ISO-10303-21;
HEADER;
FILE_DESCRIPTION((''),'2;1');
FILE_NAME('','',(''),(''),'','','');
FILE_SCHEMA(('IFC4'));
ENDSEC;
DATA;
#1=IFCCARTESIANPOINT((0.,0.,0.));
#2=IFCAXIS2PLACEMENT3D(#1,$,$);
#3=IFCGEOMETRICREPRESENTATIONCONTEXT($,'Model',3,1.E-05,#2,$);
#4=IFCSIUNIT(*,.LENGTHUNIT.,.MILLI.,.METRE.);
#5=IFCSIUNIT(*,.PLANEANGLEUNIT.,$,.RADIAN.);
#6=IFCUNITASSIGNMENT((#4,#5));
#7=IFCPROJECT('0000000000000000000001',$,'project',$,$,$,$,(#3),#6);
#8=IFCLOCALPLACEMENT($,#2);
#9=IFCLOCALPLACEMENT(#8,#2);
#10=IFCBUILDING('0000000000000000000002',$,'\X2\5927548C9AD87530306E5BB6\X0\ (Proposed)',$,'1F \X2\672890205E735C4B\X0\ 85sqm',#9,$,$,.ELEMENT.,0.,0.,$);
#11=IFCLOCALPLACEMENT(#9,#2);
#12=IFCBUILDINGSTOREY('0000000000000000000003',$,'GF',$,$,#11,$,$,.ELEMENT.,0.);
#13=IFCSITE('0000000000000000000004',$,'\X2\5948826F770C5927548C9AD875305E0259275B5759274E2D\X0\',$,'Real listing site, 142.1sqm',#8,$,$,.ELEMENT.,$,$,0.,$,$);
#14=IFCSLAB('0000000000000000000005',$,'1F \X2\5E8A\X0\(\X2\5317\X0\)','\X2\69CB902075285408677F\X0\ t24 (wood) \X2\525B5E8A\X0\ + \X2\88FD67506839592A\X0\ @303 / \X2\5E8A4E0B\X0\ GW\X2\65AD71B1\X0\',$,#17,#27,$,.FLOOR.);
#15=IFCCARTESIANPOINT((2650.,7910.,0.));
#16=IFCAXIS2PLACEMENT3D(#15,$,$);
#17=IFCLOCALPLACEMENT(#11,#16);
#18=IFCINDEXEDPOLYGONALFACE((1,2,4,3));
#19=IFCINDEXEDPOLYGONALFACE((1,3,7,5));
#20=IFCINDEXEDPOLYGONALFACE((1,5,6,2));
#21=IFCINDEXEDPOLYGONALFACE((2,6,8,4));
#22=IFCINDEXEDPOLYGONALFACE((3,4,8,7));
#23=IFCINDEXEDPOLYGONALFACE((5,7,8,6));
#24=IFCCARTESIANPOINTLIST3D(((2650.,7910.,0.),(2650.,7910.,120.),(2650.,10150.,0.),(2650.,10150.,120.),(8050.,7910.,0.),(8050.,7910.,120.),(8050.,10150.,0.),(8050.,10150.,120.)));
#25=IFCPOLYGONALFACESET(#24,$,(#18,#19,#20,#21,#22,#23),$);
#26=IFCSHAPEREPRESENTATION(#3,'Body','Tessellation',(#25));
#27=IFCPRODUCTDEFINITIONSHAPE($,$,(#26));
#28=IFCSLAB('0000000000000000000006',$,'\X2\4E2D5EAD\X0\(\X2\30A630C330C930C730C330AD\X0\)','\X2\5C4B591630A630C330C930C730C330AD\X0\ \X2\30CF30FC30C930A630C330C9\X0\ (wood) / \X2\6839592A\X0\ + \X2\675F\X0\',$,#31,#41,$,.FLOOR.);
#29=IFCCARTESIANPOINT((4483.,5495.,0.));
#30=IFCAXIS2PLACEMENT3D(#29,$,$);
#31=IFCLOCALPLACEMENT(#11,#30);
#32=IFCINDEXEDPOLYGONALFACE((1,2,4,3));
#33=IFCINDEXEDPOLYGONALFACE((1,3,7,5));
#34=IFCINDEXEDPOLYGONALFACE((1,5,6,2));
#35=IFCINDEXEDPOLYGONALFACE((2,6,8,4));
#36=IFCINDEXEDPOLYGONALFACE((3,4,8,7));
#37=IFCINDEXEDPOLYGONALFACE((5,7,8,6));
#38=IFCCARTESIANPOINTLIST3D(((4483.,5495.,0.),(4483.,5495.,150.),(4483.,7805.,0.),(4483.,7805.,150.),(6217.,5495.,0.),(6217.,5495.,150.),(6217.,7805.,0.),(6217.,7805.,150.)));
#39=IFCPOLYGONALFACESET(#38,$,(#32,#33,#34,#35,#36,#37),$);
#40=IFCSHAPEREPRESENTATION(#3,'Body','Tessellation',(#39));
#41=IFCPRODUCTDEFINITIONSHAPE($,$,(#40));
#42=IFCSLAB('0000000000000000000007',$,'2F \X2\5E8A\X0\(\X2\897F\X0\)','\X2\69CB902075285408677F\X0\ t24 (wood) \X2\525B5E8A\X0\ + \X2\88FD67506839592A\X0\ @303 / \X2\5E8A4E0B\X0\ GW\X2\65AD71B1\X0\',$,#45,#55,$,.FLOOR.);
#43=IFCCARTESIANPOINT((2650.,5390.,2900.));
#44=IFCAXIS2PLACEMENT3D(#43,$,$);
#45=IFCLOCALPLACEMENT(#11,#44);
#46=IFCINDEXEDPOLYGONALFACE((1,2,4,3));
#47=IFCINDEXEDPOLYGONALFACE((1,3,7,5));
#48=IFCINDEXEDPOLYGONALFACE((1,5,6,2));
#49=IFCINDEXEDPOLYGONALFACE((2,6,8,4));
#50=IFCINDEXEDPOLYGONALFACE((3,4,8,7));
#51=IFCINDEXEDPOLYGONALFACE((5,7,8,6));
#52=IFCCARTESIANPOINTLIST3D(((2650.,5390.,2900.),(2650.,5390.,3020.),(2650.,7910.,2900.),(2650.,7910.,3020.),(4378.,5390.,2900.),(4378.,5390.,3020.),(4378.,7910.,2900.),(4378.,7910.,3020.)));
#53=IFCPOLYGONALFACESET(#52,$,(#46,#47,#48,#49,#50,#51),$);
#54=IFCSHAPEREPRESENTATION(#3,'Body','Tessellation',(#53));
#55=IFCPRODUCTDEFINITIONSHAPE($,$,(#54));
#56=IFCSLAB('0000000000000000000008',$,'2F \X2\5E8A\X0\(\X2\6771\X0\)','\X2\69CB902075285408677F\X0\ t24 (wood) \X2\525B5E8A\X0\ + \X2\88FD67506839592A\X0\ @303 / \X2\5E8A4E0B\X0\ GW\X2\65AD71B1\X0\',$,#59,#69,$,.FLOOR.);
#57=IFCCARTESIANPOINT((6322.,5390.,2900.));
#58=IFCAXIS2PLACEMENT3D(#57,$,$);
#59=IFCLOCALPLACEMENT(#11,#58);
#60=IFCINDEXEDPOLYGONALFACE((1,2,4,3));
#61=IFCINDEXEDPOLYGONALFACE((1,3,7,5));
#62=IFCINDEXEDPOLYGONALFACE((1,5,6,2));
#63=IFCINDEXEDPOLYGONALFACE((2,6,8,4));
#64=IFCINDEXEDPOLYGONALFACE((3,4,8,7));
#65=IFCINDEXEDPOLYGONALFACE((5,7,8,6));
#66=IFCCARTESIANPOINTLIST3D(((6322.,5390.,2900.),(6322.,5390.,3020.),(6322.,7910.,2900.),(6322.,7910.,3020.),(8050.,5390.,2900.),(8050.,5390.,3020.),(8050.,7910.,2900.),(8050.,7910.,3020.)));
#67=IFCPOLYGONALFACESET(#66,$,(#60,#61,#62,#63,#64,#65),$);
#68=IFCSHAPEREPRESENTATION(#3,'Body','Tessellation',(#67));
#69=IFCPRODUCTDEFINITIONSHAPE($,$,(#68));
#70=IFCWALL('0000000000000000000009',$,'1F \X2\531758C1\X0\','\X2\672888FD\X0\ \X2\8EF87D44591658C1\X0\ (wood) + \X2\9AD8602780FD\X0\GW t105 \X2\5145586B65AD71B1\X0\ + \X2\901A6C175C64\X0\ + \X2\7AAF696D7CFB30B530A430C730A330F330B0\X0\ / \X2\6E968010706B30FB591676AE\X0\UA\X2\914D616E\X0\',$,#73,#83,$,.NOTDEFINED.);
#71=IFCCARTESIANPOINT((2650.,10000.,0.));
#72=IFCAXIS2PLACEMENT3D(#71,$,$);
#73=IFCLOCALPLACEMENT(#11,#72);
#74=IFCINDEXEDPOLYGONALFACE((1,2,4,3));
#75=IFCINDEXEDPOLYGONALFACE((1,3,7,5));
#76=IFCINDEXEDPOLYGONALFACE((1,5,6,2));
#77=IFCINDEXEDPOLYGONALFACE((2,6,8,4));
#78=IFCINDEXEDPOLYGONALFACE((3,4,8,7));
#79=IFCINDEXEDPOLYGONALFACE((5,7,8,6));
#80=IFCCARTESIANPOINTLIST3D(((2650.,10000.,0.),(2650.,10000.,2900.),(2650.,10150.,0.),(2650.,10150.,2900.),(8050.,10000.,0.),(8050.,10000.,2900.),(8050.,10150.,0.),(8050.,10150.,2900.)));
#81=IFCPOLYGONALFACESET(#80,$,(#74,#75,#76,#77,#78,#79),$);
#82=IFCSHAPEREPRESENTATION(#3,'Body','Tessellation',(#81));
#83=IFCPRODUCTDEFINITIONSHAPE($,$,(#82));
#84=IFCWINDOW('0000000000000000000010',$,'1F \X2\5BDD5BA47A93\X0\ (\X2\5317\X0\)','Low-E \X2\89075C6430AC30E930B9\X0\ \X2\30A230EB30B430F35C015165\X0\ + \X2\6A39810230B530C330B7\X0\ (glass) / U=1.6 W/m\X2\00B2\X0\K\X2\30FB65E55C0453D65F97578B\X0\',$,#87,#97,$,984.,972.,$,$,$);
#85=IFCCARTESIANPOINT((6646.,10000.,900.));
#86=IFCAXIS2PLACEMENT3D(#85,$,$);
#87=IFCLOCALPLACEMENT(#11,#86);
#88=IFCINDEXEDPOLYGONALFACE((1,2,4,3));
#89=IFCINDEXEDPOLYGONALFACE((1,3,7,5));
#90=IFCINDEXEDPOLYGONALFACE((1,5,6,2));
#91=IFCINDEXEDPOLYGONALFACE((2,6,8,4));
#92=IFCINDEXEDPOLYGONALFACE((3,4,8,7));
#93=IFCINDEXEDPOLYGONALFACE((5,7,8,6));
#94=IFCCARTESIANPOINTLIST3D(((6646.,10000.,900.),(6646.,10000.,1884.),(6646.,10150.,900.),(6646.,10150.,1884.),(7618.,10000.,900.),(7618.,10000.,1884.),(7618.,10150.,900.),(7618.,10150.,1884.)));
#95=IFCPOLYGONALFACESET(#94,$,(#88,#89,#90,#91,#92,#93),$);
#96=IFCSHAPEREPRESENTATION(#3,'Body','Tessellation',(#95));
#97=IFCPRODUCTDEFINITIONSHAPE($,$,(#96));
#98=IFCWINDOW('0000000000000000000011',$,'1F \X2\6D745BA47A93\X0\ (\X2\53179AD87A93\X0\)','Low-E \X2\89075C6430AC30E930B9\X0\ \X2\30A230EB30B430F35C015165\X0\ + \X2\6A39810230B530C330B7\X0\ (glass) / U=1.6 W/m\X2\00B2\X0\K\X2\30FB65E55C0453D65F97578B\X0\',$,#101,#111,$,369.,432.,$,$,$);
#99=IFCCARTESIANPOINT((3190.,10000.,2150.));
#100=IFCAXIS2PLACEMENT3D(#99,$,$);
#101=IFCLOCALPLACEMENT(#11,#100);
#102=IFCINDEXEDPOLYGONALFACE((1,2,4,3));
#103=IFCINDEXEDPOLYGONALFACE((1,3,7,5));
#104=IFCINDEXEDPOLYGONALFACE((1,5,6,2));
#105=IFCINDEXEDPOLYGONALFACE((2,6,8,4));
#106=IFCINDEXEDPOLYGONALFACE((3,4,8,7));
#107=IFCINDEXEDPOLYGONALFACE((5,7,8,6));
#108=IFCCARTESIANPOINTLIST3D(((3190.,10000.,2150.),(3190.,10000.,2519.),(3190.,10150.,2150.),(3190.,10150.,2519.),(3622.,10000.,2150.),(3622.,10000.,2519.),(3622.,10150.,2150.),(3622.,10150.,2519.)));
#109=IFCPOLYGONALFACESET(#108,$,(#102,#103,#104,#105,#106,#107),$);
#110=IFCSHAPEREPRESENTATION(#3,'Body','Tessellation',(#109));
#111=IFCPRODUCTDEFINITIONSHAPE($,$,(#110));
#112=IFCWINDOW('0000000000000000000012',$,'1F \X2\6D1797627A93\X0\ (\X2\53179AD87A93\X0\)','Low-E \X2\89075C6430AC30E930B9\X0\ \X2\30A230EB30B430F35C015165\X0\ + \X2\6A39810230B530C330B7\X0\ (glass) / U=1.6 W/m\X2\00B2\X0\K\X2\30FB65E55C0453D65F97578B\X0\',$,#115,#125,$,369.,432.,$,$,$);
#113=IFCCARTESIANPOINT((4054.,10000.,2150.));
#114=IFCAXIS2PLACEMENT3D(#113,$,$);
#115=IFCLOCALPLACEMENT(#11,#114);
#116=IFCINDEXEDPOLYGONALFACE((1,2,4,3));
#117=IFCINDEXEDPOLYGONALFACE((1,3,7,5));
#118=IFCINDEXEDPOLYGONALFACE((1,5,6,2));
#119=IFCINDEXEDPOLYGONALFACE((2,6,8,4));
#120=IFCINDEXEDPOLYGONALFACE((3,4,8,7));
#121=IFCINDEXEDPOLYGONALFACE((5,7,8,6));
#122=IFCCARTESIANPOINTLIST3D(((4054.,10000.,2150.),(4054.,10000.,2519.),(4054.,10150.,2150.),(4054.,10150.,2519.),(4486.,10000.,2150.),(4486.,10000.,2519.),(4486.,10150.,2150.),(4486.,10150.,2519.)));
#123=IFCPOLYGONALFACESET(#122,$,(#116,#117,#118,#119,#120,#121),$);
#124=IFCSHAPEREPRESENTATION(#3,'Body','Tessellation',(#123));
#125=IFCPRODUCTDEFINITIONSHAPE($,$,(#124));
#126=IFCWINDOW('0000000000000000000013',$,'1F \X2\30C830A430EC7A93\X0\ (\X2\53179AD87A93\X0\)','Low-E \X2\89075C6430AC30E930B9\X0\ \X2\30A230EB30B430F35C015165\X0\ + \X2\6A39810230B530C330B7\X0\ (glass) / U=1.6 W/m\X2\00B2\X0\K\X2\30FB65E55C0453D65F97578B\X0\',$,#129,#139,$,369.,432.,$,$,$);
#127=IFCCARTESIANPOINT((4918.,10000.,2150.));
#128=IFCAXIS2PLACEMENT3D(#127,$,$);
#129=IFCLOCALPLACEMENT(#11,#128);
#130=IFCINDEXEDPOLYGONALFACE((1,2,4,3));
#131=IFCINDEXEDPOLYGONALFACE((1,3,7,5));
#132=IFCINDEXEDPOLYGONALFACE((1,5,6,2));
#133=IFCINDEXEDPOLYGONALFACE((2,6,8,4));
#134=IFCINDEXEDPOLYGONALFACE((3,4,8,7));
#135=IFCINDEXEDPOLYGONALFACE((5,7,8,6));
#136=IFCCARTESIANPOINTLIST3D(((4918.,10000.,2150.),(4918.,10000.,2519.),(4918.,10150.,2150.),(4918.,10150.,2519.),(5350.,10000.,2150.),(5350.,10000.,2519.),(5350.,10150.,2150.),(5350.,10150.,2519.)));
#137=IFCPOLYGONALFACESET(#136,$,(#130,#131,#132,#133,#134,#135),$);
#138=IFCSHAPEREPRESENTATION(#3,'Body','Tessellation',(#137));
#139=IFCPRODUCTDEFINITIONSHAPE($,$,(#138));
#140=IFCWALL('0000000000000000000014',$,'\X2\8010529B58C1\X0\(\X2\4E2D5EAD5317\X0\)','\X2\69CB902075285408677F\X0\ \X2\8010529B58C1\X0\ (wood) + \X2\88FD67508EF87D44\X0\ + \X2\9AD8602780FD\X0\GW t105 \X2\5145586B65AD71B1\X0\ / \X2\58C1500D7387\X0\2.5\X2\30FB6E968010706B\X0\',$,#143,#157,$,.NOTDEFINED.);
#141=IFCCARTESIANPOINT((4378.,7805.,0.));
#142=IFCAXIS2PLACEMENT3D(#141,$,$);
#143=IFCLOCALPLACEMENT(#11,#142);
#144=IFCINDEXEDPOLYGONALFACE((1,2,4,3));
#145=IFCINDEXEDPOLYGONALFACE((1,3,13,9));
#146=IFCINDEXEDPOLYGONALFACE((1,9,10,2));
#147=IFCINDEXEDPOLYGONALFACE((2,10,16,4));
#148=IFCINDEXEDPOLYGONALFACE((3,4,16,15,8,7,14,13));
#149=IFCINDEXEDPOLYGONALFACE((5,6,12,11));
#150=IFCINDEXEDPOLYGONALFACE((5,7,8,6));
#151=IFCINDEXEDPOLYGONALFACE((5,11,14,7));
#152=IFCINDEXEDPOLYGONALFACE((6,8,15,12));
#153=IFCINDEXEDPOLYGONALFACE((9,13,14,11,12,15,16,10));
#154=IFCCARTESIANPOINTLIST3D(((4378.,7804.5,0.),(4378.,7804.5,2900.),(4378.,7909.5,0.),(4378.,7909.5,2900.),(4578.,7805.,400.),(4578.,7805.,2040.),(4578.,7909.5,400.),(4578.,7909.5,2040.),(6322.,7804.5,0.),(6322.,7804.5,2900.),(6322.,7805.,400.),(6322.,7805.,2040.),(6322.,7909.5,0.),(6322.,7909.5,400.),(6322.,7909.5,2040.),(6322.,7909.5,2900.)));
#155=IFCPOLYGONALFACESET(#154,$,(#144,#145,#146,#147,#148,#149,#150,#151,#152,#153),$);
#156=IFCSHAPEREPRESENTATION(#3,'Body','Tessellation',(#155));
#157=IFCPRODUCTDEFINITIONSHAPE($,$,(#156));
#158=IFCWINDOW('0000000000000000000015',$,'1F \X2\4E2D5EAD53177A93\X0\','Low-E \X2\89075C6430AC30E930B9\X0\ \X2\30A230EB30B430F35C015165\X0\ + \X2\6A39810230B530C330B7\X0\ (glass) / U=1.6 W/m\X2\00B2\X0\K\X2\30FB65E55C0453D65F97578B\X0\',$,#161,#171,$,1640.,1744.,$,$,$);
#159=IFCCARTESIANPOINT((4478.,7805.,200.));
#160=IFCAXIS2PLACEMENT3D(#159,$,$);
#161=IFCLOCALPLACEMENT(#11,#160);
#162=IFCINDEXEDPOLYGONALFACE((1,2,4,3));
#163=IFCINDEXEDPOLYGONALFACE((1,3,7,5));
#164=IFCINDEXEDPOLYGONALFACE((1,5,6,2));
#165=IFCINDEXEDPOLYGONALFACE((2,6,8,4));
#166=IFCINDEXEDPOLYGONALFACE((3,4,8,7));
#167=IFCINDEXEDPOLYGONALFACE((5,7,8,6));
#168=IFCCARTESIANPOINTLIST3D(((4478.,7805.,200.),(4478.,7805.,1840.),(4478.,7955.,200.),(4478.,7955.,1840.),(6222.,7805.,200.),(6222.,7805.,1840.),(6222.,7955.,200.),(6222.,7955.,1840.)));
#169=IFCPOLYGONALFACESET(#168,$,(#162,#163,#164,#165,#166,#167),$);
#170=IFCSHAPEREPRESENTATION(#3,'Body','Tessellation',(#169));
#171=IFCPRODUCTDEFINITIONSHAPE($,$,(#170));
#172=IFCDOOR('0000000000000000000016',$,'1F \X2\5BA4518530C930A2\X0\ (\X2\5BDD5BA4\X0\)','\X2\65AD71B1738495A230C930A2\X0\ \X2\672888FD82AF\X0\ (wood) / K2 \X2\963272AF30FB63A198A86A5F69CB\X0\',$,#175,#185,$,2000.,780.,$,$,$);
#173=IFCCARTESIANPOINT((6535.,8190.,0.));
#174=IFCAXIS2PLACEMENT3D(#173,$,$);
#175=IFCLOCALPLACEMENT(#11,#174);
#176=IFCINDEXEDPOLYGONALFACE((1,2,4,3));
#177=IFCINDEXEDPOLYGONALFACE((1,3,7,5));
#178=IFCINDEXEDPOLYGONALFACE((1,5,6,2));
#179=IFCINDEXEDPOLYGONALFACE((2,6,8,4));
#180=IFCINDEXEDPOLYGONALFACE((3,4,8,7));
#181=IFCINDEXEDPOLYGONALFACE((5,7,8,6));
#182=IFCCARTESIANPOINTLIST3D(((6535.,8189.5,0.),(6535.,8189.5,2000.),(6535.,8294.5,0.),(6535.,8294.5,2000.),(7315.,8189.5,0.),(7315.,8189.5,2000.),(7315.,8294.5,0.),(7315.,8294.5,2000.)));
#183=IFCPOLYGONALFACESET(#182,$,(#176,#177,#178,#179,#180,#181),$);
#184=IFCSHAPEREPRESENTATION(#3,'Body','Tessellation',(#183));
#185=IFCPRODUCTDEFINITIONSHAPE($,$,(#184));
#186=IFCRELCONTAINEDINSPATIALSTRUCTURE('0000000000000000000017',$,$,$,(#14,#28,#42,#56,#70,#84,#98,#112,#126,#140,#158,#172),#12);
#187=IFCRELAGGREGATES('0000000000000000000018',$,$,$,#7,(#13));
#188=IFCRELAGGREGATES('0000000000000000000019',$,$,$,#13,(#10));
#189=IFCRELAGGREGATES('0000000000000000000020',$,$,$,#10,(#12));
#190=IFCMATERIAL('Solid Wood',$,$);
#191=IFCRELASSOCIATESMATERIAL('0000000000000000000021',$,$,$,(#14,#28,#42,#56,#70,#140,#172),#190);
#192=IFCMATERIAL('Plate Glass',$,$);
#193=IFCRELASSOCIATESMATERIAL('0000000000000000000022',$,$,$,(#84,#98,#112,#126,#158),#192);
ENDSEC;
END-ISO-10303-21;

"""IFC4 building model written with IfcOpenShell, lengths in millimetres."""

from ifc_helpers import new_model, si_unit, frame, frame_2d, origin, place, context, project, spatial, rectangle, extrude, material, element, fill, save


model = new_model("IFC4")

# Units and contexts
model_context = context("Model", 3, precision=1e-05, world=origin())
ifc_project = project(units=[si_unit("LENGTHUNIT", "METRE", prefix="MILLI"), si_unit("PLANEANGLEUNIT", "RADIAN")], contexts=[model_context])

# Site, building, storey
site_placement = place(None, origin())
site = spatial("IfcSite", under=ifc_project, at=site_placement, Name="奈良県大和高田市大字大中", ObjectType="Real listing site, 142.1sqm", CompositionType="ELEMENT", RefElevation=0.0)
building_placement = place(site_placement, origin())
building = spatial("IfcBuilding", under=site, at=building_placement, Name="大和高田の家 (Proposed)", ObjectType="1F 木造平屋 85sqm", CompositionType="ELEMENT", ElevationOfRefHeight=0.0, ElevationOfTerrain=0.0)
storey_placement = place(building_placement, origin())
storey = spatial("IfcBuildingStorey", under=building, at=storey_placement, Name="GF", CompositionType="ELEMENT", Elevation=0.0)

# Slabs
ifc_material_1 = material(Name="Solid Wood")
slab_1_placement = place(storey_placement, frame((2650.0, 7910.0, 0.0)))
element("IfcSlab", 1, at=slab_1_placement, inside=storey, material=ifc_material_1, Name="1F 床(北)", Description="構造用合板 t24 (wood) 剛床 + 製材根太 @303 / 床下 GW断熱", PredefinedType="FLOOR", context=model_context, shape_type="SweptSolid", body=[
    extrude(rectangle(XDim=5400.0, YDim=2240.0, at=frame_2d((2700.0, 1120.0))), frame((2650.0, 7910.0, 0.0)), (0.0, 0.0, 1.0), 120.0),
])
slab_2_placement = place(storey_placement, frame((4483.0, 5495.0, 0.0)))
element("IfcSlab", 2, at=slab_2_placement, inside=storey, material=ifc_material_1, Name="中庭(ウッドデッキ)", Description="屋外ウッドデッキ ハードウッド (wood) / 根太 + 束", PredefinedType="FLOOR", context=model_context, shape_type="SweptSolid", body=[
    extrude(rectangle(XDim=1734.0, YDim=2310.0, at=frame_2d((867.0, 1155.0))), frame((4483.0, 5495.0, 0.0)), (0.0, 0.0, 1.0), 150.0),
])
slab_3_placement = place(storey_placement, frame((2650.0, 5390.0, 2900.0)))
element("IfcSlab", 3, at=slab_3_placement, inside=storey, material=ifc_material_1, Name="2F 床(西)", Description="構造用合板 t24 (wood) 剛床 + 製材根太 @303 / 床下 GW断熱", PredefinedType="FLOOR", context=model_context, shape_type="SweptSolid", body=[
    extrude(rectangle(XDim=1728.0, YDim=2520.0, at=frame_2d((864.0, 1260.0))), frame((2650.0, 5390.0, 2900.0)), (0.0, 0.0, 1.0), 120.0),
])
slab_4_placement = place(storey_placement, frame((6322.0, 5390.0, 2900.0)))
element("IfcSlab", 4, at=slab_4_placement, inside=storey, material=ifc_material_1, Name="2F 床(東)", Description="構造用合板 t24 (wood) 剛床 + 製材根太 @303 / 床下 GW断熱", PredefinedType="FLOOR", context=model_context, shape_type="SweptSolid", body=[
    extrude(rectangle(XDim=1728.0, YDim=2520.0, at=frame_2d((864.0, 1260.0))), frame((6322.0, 5390.0, 2900.0)), (0.0, 0.0, 1.0), 120.0),
])

# Wall, openings, windows
wall_1_placement = place(storey_placement, frame((2650.0, 10000.0, 0.0)))
wall_1 = element("IfcWall", 5, at=wall_1_placement, inside=storey, material=ifc_material_1, Name="1F 北壁", Description="木製 軸組外壁 (wood) + 高性能GW t105 充填断熱 + 通気層 + 窯業系サイディング / 準耐火・外皮UA配慮", PredefinedType="NOTDEFINED", context=model_context, shape_type="SweptSolid", body=[
    extrude(rectangle(XDim=5400.0, YDim=150.0, at=frame_2d((2700.0, 75.0))), frame((2650.0, 10000.0, 0.0)), (0.0, 0.0, 1.0), 2900.0),
])
opening_1_placement = place(storey_placement, frame((6646.0, 10000.0, 900.0)))
opening_1 = element("IfcOpeningElement", 6, at=opening_1_placement, cuts=wall_1, PredefinedType="NOTDEFINED", context=model_context, shape_type="SweptSolid", body=[
    extrude(rectangle(XDim=972.0, YDim=150.0, at=frame_2d((486.0, 75.0))), frame((6646.0, 10000.0, 900.0)), (0.0, 0.0, 1.0), 984.0),
])
opening_2_placement = place(storey_placement, frame((3190.0, 10000.0, 2150.0)))
opening_2 = element("IfcOpeningElement", 7, at=opening_2_placement, cuts=wall_1, PredefinedType="NOTDEFINED", context=model_context, shape_type="SweptSolid", body=[
    extrude(rectangle(XDim=432.0, YDim=150.0, at=frame_2d((216.0, 75.0))), frame((3190.0, 10000.0, 2150.0)), (0.0, 0.0, 1.0), 369.0),
])
opening_3_placement = place(storey_placement, frame((4054.0, 10000.0, 2150.0)))
opening_3 = element("IfcOpeningElement", 8, at=opening_3_placement, cuts=wall_1, PredefinedType="NOTDEFINED", context=model_context, shape_type="SweptSolid", body=[
    extrude(rectangle(XDim=432.0, YDim=150.0, at=frame_2d((216.0, 75.0))), frame((4054.0, 10000.0, 2150.0)), (0.0, 0.0, 1.0), 369.0),
])
opening_4_placement = place(storey_placement, frame((4918.0, 10000.0, 2150.0)))
opening_4 = element("IfcOpeningElement", 9, at=opening_4_placement, cuts=wall_1, PredefinedType="NOTDEFINED", context=model_context, shape_type="SweptSolid", body=[
    extrude(rectangle(XDim=432.0, YDim=150.0, at=frame_2d((216.0, 75.0))), frame((4918.0, 10000.0, 2150.0)), (0.0, 0.0, 1.0), 369.0),
])
ifc_material_2 = material(Name="Plate Glass")
window_1_placement = place(storey_placement, frame((6646.0, 10000.0, 900.0)))
window_1 = element("IfcWindow", 10, at=window_1_placement, inside=storey, material=ifc_material_2, Name="1F 寝室窓 (北)", Description="Low-E 複層ガラス アルゴン封入 + 樹脂サッシ (glass) / U=1.6 W/m²K・日射取得型", OverallHeight=984.0, OverallWidth=972.0, context=model_context, shape_type="SweptSolid", body=[
    extrude(rectangle(XDim=972.0, YDim=150.0, at=frame_2d((486.0, 75.0))), frame((6646.0, 10000.0, 900.0)), (0.0, 0.0, 1.0), 984.0),
])
fill(opening_1, window_1)
window_2_placement = place(storey_placement, frame((3190.0, 10000.0, 2150.0)))
window_2 = element("IfcWindow", 11, at=window_2_placement, inside=storey, material=ifc_material_2, Name="1F 浴室窓 (北高窓)", Description="Low-E 複層ガラス アルゴン封入 + 樹脂サッシ (glass) / U=1.6 W/m²K・日射取得型", OverallHeight=369.0, OverallWidth=432.0, context=model_context, shape_type="SweptSolid", body=[
    extrude(rectangle(XDim=432.0, YDim=150.0, at=frame_2d((216.0, 75.0))), frame((3190.0, 10000.0, 2150.0)), (0.0, 0.0, 1.0), 369.0),
])
fill(opening_2, window_2)
window_3_placement = place(storey_placement, frame((4054.0, 10000.0, 2150.0)))
window_3 = element("IfcWindow", 12, at=window_3_placement, inside=storey, material=ifc_material_2, Name="1F 洗面窓 (北高窓)", Description="Low-E 複層ガラス アルゴン封入 + 樹脂サッシ (glass) / U=1.6 W/m²K・日射取得型", OverallHeight=369.0, OverallWidth=432.0, context=model_context, shape_type="SweptSolid", body=[
    extrude(rectangle(XDim=432.0, YDim=150.0, at=frame_2d((216.0, 75.0))), frame((4054.0, 10000.0, 2150.0)), (0.0, 0.0, 1.0), 369.0),
])
fill(opening_3, window_3)
window_4_placement = place(storey_placement, frame((4918.0, 10000.0, 2150.0)))
window_4 = element("IfcWindow", 13, at=window_4_placement, inside=storey, material=ifc_material_2, Name="1F トイレ窓 (北高窓)", Description="Low-E 複層ガラス アルゴン封入 + 樹脂サッシ (glass) / U=1.6 W/m²K・日射取得型", OverallHeight=369.0, OverallWidth=432.0, context=model_context, shape_type="SweptSolid", body=[
    extrude(rectangle(XDim=432.0, YDim=150.0, at=frame_2d((216.0, 75.0))), frame((4918.0, 10000.0, 2150.0)), (0.0, 0.0, 1.0), 369.0),
])
fill(opening_4, window_4)

# Wall, opening, window
wall_2_placement = place(storey_placement, frame((4378.0, 7805.0, 0.0)))
wall_2 = element("IfcWall", 14, at=wall_2_placement, inside=storey, material=ifc_material_1, Name="耐力壁(中庭北)", Description="構造用合板 耐力壁 (wood) + 製材軸組 + 高性能GW t105 充填断熱 / 壁倍率2.5・準耐火", PredefinedType="NOTDEFINED", context=model_context, shape_type="SweptSolid", body=[
    extrude(rectangle(XDim=1944.0, YDim=105.0, at=frame_2d((972.0, 52.0))), frame((4378.0, 7805.0, 0.0)), (0.0, 0.0, 1.0), 2900.0),
])
opening_5_placement = place(storey_placement, frame((4478.0, 7805.0, 200.0)))
opening_5 = element("IfcOpeningElement", 15, at=opening_5_placement, cuts=wall_2, PredefinedType="NOTDEFINED", context=model_context, shape_type="SweptSolid", body=[
    extrude(rectangle(XDim=1744.0, YDim=150.0, at=frame_2d((872.0, 75.0))), frame((4478.0, 7805.0, 200.0)), (0.0, 0.0, 1.0), 1640.0),
])
window_5_placement = place(storey_placement, frame((4478.0, 7805.0, 200.0)))
window_5 = element("IfcWindow", 16, at=window_5_placement, inside=storey, material=ifc_material_2, Name="1F 中庭北窓", Description="Low-E 複層ガラス アルゴン封入 + 樹脂サッシ (glass) / U=1.6 W/m²K・日射取得型", OverallHeight=1640.0, OverallWidth=1744.0, context=model_context, shape_type="SweptSolid", body=[
    extrude(rectangle(XDim=1744.0, YDim=150.0, at=frame_2d((872.0, 75.0))), frame((4478.0, 7805.0, 200.0)), (0.0, 0.0, 1.0), 1640.0),
])
fill(opening_5, window_5)

# Door
door_1_placement = place(storey_placement, frame((6535.0, 8190.0, 0.0)))
element("IfcDoor", 17, at=door_1_placement, inside=storey, material=ifc_material_1, Name="1F 室内ドア (寝室)", Description="断熱玄関ドア 木製芯 (wood) / K2 防犯・採風機構", OverallHeight=2000.0, OverallWidth=780.0, context=model_context, shape_type="SweptSolid", body=[
    extrude(rectangle(XDim=780.0, YDim=105.0, at=frame_2d((390.0, 52.0))), frame((6535.0, 8190.0, 0.0)), (0.0, 0.0, 1.0), 2000.0),
])

save(model, "model.ifc")
